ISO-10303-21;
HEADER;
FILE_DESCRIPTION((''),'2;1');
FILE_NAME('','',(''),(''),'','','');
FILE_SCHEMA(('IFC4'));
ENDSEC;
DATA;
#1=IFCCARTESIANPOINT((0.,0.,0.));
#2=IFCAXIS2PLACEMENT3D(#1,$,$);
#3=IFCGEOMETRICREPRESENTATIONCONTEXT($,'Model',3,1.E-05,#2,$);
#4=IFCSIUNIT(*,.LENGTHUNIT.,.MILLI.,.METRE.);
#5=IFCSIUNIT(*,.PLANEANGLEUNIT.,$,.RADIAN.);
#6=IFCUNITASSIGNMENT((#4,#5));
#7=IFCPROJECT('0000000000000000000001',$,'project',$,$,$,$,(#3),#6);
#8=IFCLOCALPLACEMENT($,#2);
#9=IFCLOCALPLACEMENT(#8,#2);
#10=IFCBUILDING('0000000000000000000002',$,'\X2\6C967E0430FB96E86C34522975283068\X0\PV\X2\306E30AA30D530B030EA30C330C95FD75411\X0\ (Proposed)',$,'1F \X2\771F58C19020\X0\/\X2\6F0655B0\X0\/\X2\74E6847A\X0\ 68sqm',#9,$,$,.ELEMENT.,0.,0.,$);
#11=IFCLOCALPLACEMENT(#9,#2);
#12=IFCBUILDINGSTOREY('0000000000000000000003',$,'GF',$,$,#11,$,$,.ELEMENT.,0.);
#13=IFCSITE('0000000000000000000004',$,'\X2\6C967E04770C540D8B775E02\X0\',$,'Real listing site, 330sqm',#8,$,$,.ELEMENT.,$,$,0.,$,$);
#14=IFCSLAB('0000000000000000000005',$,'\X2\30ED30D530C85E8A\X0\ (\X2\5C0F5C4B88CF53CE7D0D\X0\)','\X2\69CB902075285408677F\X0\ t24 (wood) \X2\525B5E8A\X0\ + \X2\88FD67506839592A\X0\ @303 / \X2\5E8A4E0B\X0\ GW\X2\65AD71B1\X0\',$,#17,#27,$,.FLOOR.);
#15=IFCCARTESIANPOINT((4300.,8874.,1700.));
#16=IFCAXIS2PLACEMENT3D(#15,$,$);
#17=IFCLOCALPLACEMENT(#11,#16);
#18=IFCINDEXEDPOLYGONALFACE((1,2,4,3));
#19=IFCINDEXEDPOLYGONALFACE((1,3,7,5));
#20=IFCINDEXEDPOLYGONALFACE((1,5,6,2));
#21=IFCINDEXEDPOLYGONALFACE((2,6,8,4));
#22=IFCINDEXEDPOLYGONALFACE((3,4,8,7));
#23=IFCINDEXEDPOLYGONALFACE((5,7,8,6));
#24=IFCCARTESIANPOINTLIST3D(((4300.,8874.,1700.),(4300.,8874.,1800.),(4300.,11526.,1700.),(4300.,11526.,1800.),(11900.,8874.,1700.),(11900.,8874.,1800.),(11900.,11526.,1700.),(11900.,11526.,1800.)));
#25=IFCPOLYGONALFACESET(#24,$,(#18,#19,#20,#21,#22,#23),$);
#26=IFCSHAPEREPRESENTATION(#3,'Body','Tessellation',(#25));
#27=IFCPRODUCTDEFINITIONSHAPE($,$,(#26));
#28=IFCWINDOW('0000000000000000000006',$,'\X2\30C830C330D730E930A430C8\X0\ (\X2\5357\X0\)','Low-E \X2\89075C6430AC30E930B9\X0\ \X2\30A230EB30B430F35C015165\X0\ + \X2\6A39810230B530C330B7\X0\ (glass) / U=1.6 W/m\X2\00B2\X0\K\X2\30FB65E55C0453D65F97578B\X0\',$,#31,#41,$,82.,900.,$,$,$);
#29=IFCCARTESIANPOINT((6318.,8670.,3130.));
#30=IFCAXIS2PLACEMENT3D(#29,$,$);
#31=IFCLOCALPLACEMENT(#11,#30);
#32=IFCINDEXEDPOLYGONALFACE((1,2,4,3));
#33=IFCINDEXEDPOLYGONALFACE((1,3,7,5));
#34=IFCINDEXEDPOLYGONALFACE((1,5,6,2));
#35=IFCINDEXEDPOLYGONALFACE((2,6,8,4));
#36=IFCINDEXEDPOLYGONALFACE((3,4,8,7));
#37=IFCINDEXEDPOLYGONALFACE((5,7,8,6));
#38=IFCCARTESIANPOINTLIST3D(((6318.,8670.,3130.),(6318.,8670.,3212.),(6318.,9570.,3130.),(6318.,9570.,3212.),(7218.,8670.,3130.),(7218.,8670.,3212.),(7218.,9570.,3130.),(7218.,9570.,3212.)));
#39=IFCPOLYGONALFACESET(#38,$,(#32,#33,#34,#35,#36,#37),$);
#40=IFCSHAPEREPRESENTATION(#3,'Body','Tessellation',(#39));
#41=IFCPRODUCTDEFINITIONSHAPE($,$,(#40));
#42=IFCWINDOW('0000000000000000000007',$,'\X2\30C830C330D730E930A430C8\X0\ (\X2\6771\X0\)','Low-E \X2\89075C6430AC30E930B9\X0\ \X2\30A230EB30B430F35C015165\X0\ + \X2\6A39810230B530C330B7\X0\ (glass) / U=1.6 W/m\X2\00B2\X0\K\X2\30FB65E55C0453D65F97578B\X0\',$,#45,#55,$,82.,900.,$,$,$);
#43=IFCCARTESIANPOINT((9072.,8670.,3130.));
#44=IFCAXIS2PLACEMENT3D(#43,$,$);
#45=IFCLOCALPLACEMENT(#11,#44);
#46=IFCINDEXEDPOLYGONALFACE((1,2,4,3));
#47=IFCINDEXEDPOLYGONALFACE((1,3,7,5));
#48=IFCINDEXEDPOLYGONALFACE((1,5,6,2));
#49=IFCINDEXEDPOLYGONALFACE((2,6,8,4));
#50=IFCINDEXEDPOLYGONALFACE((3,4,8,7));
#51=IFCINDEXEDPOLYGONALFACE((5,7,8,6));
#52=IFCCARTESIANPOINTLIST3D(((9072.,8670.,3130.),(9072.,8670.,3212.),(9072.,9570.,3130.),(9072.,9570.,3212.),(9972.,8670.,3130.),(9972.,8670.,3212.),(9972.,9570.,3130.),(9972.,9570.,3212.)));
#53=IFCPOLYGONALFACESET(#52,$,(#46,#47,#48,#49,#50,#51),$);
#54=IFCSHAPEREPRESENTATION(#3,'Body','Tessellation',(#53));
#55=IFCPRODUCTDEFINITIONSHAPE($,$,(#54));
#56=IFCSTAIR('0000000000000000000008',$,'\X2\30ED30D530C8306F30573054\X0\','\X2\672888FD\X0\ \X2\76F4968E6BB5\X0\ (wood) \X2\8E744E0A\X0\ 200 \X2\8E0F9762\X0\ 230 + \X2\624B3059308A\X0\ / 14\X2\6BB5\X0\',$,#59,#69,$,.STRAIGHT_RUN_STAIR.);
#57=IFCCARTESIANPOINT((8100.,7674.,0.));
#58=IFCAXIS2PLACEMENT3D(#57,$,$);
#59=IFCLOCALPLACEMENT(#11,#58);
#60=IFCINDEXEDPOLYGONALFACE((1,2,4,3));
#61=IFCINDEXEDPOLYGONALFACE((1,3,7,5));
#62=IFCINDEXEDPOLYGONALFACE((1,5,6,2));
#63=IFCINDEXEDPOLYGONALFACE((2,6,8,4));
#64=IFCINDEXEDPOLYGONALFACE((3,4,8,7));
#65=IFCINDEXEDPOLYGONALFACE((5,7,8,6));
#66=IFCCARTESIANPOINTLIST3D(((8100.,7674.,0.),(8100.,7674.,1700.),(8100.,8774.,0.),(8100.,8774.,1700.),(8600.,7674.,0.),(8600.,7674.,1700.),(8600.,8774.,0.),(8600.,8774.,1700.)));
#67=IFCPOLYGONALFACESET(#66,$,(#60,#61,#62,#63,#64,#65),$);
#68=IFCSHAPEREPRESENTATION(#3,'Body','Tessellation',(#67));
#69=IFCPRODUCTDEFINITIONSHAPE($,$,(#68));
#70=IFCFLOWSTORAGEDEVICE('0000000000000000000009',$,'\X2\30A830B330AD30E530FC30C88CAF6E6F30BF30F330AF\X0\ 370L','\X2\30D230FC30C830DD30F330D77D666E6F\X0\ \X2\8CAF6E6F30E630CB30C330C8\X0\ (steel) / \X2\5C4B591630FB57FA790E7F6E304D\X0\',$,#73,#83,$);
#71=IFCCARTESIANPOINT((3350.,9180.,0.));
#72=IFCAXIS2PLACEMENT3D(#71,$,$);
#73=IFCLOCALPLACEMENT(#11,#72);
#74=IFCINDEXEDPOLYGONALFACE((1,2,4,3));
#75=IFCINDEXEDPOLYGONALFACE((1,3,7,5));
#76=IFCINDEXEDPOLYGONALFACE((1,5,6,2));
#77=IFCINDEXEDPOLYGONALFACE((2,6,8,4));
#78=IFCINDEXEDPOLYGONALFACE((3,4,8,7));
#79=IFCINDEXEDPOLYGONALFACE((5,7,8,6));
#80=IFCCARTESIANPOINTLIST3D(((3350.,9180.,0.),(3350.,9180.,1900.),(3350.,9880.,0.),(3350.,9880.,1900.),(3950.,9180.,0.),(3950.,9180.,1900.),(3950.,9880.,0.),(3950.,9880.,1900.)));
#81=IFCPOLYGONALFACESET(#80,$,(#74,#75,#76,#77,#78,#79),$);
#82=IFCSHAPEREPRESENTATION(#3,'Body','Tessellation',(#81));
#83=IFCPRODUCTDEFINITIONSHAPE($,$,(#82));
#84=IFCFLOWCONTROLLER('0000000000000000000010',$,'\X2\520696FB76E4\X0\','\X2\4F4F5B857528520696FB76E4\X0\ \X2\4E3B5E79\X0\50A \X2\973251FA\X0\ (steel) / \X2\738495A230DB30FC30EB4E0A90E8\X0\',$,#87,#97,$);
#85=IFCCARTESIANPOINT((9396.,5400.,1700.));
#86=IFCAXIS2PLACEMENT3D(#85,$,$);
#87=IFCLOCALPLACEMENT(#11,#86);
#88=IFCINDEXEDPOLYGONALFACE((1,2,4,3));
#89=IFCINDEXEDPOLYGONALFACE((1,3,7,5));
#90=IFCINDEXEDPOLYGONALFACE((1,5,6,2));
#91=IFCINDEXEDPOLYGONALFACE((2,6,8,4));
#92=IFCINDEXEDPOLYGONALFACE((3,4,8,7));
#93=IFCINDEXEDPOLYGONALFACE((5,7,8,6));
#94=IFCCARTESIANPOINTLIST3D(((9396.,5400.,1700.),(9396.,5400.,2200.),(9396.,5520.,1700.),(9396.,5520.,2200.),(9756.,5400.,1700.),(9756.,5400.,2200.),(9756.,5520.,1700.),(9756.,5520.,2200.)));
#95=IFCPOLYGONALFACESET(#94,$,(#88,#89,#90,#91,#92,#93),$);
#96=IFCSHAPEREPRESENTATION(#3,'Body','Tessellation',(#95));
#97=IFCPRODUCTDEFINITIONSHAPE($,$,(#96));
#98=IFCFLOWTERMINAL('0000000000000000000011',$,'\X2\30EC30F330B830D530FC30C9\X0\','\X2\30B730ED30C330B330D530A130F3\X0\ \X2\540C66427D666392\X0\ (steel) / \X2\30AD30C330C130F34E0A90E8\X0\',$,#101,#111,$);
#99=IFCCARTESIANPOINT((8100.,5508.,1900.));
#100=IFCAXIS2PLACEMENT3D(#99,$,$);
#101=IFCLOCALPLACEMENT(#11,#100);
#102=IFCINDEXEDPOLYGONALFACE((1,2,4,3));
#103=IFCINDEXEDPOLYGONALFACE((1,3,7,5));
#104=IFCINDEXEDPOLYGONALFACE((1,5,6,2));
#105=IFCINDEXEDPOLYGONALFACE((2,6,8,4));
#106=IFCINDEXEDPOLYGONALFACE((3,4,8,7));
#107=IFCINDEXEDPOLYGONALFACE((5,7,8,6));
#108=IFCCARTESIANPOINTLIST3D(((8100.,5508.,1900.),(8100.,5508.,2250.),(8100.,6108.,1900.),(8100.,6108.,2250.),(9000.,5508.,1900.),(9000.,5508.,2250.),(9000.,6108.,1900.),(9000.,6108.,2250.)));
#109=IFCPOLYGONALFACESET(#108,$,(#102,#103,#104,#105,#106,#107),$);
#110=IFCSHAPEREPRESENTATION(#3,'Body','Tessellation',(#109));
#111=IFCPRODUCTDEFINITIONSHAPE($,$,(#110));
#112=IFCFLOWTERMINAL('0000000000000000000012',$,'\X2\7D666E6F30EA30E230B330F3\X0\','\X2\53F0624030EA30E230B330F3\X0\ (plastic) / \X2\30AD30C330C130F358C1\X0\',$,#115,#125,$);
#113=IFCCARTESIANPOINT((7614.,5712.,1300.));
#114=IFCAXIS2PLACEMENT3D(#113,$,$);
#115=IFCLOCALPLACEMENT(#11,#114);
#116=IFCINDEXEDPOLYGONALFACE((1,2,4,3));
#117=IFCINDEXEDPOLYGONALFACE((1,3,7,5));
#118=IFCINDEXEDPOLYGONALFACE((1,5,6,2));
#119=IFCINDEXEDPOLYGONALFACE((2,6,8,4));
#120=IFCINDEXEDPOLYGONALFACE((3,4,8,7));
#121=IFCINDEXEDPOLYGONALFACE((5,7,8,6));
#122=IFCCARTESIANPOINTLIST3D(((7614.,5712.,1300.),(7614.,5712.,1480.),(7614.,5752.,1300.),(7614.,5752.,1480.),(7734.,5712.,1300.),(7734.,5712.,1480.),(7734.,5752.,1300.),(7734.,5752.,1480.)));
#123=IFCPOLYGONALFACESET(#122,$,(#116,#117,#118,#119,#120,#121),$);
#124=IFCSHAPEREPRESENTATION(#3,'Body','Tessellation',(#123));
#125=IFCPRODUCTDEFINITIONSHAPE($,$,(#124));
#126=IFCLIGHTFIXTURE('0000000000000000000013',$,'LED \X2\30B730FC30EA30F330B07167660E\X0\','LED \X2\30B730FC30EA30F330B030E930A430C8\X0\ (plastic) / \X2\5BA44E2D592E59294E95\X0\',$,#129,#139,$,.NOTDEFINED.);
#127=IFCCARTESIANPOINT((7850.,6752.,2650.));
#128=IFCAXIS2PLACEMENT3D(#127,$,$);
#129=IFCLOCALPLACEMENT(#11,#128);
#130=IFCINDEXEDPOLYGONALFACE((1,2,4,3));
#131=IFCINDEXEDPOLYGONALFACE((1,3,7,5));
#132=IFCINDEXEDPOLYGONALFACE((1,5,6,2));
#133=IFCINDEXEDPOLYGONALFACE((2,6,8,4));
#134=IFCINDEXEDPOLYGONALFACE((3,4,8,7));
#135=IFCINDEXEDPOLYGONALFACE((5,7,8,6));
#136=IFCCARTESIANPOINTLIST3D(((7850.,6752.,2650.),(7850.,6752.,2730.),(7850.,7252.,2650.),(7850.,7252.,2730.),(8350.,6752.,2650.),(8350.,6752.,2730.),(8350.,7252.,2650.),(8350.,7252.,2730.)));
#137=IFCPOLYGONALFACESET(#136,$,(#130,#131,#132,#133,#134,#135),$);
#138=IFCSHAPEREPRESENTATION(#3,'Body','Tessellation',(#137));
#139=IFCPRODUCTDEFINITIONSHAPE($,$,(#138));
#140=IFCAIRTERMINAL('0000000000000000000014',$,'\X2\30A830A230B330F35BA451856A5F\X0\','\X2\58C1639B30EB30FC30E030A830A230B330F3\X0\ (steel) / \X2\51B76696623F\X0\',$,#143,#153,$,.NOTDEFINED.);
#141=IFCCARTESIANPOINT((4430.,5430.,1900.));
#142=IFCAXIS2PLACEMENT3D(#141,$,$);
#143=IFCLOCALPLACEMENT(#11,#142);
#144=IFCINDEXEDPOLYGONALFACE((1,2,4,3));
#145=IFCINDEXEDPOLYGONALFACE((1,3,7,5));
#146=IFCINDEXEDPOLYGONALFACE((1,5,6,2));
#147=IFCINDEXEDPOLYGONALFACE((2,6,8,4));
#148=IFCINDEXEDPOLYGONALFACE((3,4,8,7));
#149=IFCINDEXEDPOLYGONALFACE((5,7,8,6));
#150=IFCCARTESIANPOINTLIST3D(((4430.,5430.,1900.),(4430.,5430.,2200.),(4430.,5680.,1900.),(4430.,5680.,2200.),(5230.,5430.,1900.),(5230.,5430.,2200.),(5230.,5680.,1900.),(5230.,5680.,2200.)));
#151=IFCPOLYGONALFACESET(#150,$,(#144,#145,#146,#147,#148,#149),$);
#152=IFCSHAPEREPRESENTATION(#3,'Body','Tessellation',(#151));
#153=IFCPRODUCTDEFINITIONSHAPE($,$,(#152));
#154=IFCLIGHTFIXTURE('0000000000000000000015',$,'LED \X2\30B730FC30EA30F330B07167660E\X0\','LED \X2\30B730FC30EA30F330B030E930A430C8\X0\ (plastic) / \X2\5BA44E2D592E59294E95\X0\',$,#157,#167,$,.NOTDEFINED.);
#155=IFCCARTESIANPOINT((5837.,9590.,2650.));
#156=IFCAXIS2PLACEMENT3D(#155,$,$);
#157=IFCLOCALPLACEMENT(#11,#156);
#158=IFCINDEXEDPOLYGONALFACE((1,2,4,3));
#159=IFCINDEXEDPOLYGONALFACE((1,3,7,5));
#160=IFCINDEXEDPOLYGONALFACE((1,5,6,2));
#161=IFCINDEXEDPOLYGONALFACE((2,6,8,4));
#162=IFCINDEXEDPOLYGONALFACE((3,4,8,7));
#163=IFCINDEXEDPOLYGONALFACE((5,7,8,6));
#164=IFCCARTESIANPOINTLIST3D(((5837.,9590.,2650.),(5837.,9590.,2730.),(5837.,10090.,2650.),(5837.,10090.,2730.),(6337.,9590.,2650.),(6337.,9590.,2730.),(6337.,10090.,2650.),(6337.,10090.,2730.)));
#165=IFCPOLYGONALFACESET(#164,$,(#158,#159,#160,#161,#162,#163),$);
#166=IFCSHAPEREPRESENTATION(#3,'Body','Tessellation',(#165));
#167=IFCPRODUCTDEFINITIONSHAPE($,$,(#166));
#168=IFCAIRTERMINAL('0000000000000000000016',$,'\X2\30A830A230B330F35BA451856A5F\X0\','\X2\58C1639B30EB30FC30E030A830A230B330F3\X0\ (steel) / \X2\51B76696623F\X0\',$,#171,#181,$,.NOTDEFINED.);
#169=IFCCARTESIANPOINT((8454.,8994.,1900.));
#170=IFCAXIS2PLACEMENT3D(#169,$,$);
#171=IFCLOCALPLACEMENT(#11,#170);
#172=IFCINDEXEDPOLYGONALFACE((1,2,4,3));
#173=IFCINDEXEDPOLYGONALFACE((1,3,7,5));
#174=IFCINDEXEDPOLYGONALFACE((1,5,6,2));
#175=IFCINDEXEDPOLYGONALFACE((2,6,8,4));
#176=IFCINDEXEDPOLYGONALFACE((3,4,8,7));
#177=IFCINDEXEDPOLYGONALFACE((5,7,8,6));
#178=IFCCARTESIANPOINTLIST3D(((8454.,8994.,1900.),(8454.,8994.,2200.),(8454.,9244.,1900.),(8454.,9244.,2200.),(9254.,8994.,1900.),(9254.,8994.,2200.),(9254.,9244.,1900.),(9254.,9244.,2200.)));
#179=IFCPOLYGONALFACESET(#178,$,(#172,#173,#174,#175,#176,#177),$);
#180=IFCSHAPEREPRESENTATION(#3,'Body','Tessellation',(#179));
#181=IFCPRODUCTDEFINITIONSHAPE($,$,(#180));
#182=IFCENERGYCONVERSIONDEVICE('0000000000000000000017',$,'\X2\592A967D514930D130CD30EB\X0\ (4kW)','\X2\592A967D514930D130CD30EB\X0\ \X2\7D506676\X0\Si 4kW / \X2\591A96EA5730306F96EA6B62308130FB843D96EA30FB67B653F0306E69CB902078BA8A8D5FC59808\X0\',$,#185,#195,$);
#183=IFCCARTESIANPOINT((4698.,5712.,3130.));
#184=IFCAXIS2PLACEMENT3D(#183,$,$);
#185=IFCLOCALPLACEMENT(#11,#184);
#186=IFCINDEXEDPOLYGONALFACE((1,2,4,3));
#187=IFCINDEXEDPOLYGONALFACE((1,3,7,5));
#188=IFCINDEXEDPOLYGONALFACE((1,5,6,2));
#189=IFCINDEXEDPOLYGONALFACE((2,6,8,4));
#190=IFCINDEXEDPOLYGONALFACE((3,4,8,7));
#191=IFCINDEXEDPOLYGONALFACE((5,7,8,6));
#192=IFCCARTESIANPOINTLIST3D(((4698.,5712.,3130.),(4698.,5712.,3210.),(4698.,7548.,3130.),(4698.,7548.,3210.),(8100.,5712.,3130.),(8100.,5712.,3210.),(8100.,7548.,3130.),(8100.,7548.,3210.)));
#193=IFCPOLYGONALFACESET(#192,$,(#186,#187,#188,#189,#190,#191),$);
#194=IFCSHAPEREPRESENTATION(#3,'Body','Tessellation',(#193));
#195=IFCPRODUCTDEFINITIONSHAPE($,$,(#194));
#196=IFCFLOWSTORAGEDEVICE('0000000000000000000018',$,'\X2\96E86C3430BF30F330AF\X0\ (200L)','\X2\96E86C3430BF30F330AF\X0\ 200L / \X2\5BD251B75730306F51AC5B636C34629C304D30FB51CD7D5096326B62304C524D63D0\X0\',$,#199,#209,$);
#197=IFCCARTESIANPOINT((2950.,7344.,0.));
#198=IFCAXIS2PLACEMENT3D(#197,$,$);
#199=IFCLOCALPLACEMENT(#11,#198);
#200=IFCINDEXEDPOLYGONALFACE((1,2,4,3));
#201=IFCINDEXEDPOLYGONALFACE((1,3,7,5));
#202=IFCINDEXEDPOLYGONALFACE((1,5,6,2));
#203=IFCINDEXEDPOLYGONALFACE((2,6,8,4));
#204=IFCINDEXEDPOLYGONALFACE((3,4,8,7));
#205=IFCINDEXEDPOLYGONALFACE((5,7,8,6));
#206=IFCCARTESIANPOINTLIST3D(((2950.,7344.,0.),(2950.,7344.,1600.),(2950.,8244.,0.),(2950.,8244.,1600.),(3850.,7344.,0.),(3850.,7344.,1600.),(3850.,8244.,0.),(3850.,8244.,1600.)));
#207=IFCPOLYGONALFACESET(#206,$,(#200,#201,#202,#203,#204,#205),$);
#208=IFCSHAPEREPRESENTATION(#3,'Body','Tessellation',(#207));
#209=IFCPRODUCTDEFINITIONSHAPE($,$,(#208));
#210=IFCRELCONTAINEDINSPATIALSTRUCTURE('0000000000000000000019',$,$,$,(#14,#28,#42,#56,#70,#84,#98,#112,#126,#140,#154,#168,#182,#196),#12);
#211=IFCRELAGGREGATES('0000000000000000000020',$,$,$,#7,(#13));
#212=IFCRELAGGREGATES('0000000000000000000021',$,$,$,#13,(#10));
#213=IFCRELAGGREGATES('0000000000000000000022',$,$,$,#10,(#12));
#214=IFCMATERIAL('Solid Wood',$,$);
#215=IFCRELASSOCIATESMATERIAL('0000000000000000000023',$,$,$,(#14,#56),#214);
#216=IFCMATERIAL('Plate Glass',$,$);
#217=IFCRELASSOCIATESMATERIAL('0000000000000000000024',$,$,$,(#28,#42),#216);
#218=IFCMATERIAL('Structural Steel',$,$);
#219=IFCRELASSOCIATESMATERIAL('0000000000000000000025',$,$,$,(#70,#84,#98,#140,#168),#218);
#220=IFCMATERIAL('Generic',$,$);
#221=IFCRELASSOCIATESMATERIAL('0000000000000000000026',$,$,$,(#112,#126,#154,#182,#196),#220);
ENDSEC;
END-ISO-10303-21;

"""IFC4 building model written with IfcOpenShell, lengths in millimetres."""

from ifc_helpers import new_model, si_unit, frame, frame_2d, origin, place, context, project, spatial, rectangle, extrude, material, element, save


model = new_model("IFC4")

# Units and contexts
model_context = context("Model", 3, precision=1e-05, world=origin())
ifc_project = project(units=[si_unit("LENGTHUNIT", "METRE", prefix="MILLI"), si_unit("PLANEANGLEUNIT", "RADIAN")], contexts=[model_context])

# Site, building, storey
site_placement = place(None, origin())
site = spatial("IfcSite", under=ifc_project, at=site_placement, Name="沖縄県名護市", ObjectType="Real listing site, 330sqm", CompositionType="ELEMENT", RefElevation=0.0)
building_placement = place(site_placement, origin())
building = spatial("IfcBuilding", under=site, at=building_placement, Name="沖縄・雨水利用とPVのオフグリッド志向 (Proposed)", ObjectType="1F 真壁造/漆喰/瓦葺 68sqm", CompositionType="ELEMENT", ElevationOfRefHeight=0.0, ElevationOfTerrain=0.0)
storey_placement = place(building_placement, origin())
storey = spatial("IfcBuildingStorey", under=building, at=storey_placement, Name="GF", CompositionType="ELEMENT", Elevation=0.0)

# Shared definitions
ifc_material_1 = material(Name="Solid Wood")

# Slab
slab_placement = place(storey_placement, frame((4300.0, 8874.0, 1700.0)))
element("IfcSlab", 1, at=slab_placement, inside=storey, material=ifc_material_1, Name="ロフト床 (小屋裏収納)", Description="構造用合板 t24 (wood) 剛床 + 製材根太 @303 / 床下 GW断熱", PredefinedType="FLOOR", context=model_context, shape_type="SweptSolid", body=[
    extrude(rectangle(XDim=7600.0, YDim=2652.0, at=frame_2d((3800.0, 1326.0))), frame((4300.0, 8874.0, 1700.0)), (0.0, 0.0, 1.0), 100.0),
])

# Windows
ifc_material_2 = material(Name="Plate Glass")
window_1_placement = place(storey_placement, frame((6318.0, 8670.0, 3130.0)))
element("IfcWindow", 2, at=window_1_placement, inside=storey, material=ifc_material_2, Name="トップライト (南)", Description="Low-E 複層ガラス アルゴン封入 + 樹脂サッシ (glass) / U=1.6 W/m²K・日射取得型", OverallHeight=82.0, OverallWidth=900.0, context=model_context, shape_type="SweptSolid", body=[
    extrude(rectangle(XDim=900.0, YDim=900.0, at=frame_2d((450.0, 450.0))), frame((6318.0, 8670.0, 3130.0)), (0.0, 0.0, 1.0), 82.0),
])
window_2_placement = place(storey_placement, frame((9072.0, 8670.0, 3130.0)))
element("IfcWindow", 3, at=window_2_placement, inside=storey, material=ifc_material_2, Name="トップライト (東)", Description="Low-E 複層ガラス アルゴン封入 + 樹脂サッシ (glass) / U=1.6 W/m²K・日射取得型", OverallHeight=82.0, OverallWidth=900.0, context=model_context, shape_type="SweptSolid", body=[
    extrude(rectangle(XDim=900.0, YDim=900.0, at=frame_2d((450.0, 450.0))), frame((9072.0, 8670.0, 3130.0)), (0.0, 0.0, 1.0), 82.0),
])

# Stair
stair_placement = place(storey_placement, frame((8100.0, 7674.0, 0.0)))
element("IfcStair", 4, at=stair_placement, inside=storey, material=ifc_material_1, Name="ロフトはしご", Description="木製 直階段 (wood) 蹴上 200 踏面 230 + 手すり / 14段", PredefinedType="STRAIGHT_RUN_STAIR", context=model_context, shape_type="SweptSolid", body=[
    extrude(rectangle(XDim=500.0, YDim=1100.0, at=frame_2d((250.0, 550.0))), frame((8100.0, 7674.0, 0.0)), (0.0, 0.0, 1.0), 1700.0),
])

# Flow storage device
ifc_material_3 = material(Name="Structural Steel")
flow_storage_device_1_placement = place(storey_placement, frame((3350.0, 9180.0, 0.0)))
element("IfcFlowStorageDevice", 5, at=flow_storage_device_1_placement, inside=storey, material=ifc_material_3, Name="エコキュート貯湯タンク 370L", Description="ヒートポンプ給湯 貯湯ユニット (steel) / 屋外・基礎置き", context=model_context, shape_type="SweptSolid", body=[
    extrude(rectangle(XDim=600.0, YDim=700.0, at=frame_2d((300.0, 350.0))), frame((3350.0, 9180.0, 0.0)), (0.0, 0.0, 1.0), 1900.0),
])

# Flow controller
flow_controller_placement = place(storey_placement, frame((9396.0, 5400.0, 1700.0)))
element("IfcFlowController", 6, at=flow_controller_placement, inside=storey, material=ifc_material_3, Name="分電盤", Description="住宅用分電盤 主幹50A 露出 (steel) / 玄関ホール上部", context=model_context, shape_type="SweptSolid", body=[
    extrude(rectangle(XDim=360.0, YDim=120.0, at=frame_2d((180.0, 60.0))), frame((9396.0, 5400.0, 1700.0)), (0.0, 0.0, 1.0), 500.0),
])

# Flow terminals
flow_terminal_1_placement = place(storey_placement, frame((8100.0, 5508.0, 1900.0)))
element("IfcFlowTerminal", 7, at=flow_terminal_1_placement, inside=storey, material=ifc_material_3, Name="レンジフード", Description="シロッコファン 同時給排 (steel) / キッチン上部", context=model_context, shape_type="SweptSolid", body=[
    extrude(rectangle(XDim=900.0, YDim=600.0, at=frame_2d((450.0, 300.0))), frame((8100.0, 5508.0, 1900.0)), (0.0, 0.0, 1.0), 350.0),
])
ifc_material_4 = material(Name="Generic")
flow_terminal_2_placement = place(storey_placement, frame((7614.0, 5712.0, 1300.0)))
element("IfcFlowTerminal", 8, at=flow_terminal_2_placement, inside=storey, material=ifc_material_4, Name="給湯リモコン", Description="台所リモコン (plastic) / キッチン壁", context=model_context, shape_type="SweptSolid", body=[
    extrude(rectangle(XDim=120.0, YDim=40.0, at=frame_2d((60.0, 20.0))), frame((7614.0, 5712.0, 1300.0)), (0.0, 0.0, 1.0), 180.0),
])

# Light fixture
light_fixture_1_placement = place(storey_placement, frame((7850.0, 6752.0, 2650.0)))
element("IfcLightFixture", 9, at=light_fixture_1_placement, inside=storey, material=ifc_material_4, Name="LED シーリング照明", Description="LED シーリングライト (plastic) / 室中央天井", PredefinedType="NOTDEFINED", context=model_context, shape_type="SweptSolid", body=[
    extrude(rectangle(XDim=500.0, YDim=500.0, at=frame_2d((250.0, 250.0))), frame((7850.0, 6752.0, 2650.0)), (0.0, 0.0, 1.0), 80.0),
])

# Air terminal
air_terminal_1_placement = place(storey_placement, frame((4430.0, 5430.0, 1900.0)))
element("IfcAirTerminal", 10, at=air_terminal_1_placement, inside=storey, material=ifc_material_3, Name="エアコン室内機", Description="壁掛ルームエアコン (steel) / 冷暖房", PredefinedType="NOTDEFINED", context=model_context, shape_type="SweptSolid", body=[
    extrude(rectangle(XDim=800.0, YDim=250.0, at=frame_2d((400.0, 125.0))), frame((4430.0, 5430.0, 1900.0)), (0.0, 0.0, 1.0), 300.0),
])

# Light fixture
light_fixture_2_placement = place(storey_placement, frame((5837.0, 9590.0, 2650.0)))
element("IfcLightFixture", 11, at=light_fixture_2_placement, inside=storey, material=ifc_material_4, Name="LED シーリング照明", Description="LED シーリングライト (plastic) / 室中央天井", PredefinedType="NOTDEFINED", context=model_context, shape_type="SweptSolid", body=[
    extrude(rectangle(XDim=500.0, YDim=500.0, at=frame_2d((250.0, 250.0))), frame((5837.0, 9590.0, 2650.0)), (0.0, 0.0, 1.0), 80.0),
])

# Air terminal
air_terminal_2_placement = place(storey_placement, frame((8454.0, 8994.0, 1900.0)))
element("IfcAirTerminal", 12, at=air_terminal_2_placement, inside=storey, material=ifc_material_3, Name="エアコン室内機", Description="壁掛ルームエアコン (steel) / 冷暖房", PredefinedType="NOTDEFINED", context=model_context, shape_type="SweptSolid", body=[
    extrude(rectangle(XDim=800.0, YDim=250.0, at=frame_2d((400.0, 125.0))), frame((8454.0, 8994.0, 1900.0)), (0.0, 0.0, 1.0), 300.0),
])

# Energy conversion device
energy_conversion_device_placement = place(storey_placement, frame((4698.0, 5712.0, 3130.0)))
element("IfcEnergyConversionDevice", 13, at=energy_conversion_device_placement, inside=storey, material=ifc_material_4, Name="太陽光パネル (4kW)", Description="太陽光パネル 結晶Si 4kW / 多雪地は雪止め・落雪・架台の構造確認必須", context=model_context, shape_type="SweptSolid", body=[
    extrude(rectangle(XDim=3402.0, YDim=1836.0, at=frame_2d((1701.0, 918.0))), frame((4698.0, 5712.0, 3130.0)), (0.0, 0.0, 1.0), 80.0),
])

# Flow storage device
flow_storage_device_2_placement = place(storey_placement, frame((2950.0, 7344.0, 0.0)))
element("IfcFlowStorageDevice", 14, at=flow_storage_device_2_placement, inside=storey, material=ifc_material_4, Name="雨水タンク (200L)", Description="雨水タンク 200L / 寒冷地は冬季水抜き・凍結防止が前提", context=model_context, shape_type="SweptSolid", body=[
    extrude(rectangle(XDim=900.0, YDim=900.0, at=frame_2d((450.0, 450.0))), frame((2950.0, 7344.0, 0.0)), (0.0, 0.0, 1.0), 1600.0),
])

save(model, "model.ifc")
